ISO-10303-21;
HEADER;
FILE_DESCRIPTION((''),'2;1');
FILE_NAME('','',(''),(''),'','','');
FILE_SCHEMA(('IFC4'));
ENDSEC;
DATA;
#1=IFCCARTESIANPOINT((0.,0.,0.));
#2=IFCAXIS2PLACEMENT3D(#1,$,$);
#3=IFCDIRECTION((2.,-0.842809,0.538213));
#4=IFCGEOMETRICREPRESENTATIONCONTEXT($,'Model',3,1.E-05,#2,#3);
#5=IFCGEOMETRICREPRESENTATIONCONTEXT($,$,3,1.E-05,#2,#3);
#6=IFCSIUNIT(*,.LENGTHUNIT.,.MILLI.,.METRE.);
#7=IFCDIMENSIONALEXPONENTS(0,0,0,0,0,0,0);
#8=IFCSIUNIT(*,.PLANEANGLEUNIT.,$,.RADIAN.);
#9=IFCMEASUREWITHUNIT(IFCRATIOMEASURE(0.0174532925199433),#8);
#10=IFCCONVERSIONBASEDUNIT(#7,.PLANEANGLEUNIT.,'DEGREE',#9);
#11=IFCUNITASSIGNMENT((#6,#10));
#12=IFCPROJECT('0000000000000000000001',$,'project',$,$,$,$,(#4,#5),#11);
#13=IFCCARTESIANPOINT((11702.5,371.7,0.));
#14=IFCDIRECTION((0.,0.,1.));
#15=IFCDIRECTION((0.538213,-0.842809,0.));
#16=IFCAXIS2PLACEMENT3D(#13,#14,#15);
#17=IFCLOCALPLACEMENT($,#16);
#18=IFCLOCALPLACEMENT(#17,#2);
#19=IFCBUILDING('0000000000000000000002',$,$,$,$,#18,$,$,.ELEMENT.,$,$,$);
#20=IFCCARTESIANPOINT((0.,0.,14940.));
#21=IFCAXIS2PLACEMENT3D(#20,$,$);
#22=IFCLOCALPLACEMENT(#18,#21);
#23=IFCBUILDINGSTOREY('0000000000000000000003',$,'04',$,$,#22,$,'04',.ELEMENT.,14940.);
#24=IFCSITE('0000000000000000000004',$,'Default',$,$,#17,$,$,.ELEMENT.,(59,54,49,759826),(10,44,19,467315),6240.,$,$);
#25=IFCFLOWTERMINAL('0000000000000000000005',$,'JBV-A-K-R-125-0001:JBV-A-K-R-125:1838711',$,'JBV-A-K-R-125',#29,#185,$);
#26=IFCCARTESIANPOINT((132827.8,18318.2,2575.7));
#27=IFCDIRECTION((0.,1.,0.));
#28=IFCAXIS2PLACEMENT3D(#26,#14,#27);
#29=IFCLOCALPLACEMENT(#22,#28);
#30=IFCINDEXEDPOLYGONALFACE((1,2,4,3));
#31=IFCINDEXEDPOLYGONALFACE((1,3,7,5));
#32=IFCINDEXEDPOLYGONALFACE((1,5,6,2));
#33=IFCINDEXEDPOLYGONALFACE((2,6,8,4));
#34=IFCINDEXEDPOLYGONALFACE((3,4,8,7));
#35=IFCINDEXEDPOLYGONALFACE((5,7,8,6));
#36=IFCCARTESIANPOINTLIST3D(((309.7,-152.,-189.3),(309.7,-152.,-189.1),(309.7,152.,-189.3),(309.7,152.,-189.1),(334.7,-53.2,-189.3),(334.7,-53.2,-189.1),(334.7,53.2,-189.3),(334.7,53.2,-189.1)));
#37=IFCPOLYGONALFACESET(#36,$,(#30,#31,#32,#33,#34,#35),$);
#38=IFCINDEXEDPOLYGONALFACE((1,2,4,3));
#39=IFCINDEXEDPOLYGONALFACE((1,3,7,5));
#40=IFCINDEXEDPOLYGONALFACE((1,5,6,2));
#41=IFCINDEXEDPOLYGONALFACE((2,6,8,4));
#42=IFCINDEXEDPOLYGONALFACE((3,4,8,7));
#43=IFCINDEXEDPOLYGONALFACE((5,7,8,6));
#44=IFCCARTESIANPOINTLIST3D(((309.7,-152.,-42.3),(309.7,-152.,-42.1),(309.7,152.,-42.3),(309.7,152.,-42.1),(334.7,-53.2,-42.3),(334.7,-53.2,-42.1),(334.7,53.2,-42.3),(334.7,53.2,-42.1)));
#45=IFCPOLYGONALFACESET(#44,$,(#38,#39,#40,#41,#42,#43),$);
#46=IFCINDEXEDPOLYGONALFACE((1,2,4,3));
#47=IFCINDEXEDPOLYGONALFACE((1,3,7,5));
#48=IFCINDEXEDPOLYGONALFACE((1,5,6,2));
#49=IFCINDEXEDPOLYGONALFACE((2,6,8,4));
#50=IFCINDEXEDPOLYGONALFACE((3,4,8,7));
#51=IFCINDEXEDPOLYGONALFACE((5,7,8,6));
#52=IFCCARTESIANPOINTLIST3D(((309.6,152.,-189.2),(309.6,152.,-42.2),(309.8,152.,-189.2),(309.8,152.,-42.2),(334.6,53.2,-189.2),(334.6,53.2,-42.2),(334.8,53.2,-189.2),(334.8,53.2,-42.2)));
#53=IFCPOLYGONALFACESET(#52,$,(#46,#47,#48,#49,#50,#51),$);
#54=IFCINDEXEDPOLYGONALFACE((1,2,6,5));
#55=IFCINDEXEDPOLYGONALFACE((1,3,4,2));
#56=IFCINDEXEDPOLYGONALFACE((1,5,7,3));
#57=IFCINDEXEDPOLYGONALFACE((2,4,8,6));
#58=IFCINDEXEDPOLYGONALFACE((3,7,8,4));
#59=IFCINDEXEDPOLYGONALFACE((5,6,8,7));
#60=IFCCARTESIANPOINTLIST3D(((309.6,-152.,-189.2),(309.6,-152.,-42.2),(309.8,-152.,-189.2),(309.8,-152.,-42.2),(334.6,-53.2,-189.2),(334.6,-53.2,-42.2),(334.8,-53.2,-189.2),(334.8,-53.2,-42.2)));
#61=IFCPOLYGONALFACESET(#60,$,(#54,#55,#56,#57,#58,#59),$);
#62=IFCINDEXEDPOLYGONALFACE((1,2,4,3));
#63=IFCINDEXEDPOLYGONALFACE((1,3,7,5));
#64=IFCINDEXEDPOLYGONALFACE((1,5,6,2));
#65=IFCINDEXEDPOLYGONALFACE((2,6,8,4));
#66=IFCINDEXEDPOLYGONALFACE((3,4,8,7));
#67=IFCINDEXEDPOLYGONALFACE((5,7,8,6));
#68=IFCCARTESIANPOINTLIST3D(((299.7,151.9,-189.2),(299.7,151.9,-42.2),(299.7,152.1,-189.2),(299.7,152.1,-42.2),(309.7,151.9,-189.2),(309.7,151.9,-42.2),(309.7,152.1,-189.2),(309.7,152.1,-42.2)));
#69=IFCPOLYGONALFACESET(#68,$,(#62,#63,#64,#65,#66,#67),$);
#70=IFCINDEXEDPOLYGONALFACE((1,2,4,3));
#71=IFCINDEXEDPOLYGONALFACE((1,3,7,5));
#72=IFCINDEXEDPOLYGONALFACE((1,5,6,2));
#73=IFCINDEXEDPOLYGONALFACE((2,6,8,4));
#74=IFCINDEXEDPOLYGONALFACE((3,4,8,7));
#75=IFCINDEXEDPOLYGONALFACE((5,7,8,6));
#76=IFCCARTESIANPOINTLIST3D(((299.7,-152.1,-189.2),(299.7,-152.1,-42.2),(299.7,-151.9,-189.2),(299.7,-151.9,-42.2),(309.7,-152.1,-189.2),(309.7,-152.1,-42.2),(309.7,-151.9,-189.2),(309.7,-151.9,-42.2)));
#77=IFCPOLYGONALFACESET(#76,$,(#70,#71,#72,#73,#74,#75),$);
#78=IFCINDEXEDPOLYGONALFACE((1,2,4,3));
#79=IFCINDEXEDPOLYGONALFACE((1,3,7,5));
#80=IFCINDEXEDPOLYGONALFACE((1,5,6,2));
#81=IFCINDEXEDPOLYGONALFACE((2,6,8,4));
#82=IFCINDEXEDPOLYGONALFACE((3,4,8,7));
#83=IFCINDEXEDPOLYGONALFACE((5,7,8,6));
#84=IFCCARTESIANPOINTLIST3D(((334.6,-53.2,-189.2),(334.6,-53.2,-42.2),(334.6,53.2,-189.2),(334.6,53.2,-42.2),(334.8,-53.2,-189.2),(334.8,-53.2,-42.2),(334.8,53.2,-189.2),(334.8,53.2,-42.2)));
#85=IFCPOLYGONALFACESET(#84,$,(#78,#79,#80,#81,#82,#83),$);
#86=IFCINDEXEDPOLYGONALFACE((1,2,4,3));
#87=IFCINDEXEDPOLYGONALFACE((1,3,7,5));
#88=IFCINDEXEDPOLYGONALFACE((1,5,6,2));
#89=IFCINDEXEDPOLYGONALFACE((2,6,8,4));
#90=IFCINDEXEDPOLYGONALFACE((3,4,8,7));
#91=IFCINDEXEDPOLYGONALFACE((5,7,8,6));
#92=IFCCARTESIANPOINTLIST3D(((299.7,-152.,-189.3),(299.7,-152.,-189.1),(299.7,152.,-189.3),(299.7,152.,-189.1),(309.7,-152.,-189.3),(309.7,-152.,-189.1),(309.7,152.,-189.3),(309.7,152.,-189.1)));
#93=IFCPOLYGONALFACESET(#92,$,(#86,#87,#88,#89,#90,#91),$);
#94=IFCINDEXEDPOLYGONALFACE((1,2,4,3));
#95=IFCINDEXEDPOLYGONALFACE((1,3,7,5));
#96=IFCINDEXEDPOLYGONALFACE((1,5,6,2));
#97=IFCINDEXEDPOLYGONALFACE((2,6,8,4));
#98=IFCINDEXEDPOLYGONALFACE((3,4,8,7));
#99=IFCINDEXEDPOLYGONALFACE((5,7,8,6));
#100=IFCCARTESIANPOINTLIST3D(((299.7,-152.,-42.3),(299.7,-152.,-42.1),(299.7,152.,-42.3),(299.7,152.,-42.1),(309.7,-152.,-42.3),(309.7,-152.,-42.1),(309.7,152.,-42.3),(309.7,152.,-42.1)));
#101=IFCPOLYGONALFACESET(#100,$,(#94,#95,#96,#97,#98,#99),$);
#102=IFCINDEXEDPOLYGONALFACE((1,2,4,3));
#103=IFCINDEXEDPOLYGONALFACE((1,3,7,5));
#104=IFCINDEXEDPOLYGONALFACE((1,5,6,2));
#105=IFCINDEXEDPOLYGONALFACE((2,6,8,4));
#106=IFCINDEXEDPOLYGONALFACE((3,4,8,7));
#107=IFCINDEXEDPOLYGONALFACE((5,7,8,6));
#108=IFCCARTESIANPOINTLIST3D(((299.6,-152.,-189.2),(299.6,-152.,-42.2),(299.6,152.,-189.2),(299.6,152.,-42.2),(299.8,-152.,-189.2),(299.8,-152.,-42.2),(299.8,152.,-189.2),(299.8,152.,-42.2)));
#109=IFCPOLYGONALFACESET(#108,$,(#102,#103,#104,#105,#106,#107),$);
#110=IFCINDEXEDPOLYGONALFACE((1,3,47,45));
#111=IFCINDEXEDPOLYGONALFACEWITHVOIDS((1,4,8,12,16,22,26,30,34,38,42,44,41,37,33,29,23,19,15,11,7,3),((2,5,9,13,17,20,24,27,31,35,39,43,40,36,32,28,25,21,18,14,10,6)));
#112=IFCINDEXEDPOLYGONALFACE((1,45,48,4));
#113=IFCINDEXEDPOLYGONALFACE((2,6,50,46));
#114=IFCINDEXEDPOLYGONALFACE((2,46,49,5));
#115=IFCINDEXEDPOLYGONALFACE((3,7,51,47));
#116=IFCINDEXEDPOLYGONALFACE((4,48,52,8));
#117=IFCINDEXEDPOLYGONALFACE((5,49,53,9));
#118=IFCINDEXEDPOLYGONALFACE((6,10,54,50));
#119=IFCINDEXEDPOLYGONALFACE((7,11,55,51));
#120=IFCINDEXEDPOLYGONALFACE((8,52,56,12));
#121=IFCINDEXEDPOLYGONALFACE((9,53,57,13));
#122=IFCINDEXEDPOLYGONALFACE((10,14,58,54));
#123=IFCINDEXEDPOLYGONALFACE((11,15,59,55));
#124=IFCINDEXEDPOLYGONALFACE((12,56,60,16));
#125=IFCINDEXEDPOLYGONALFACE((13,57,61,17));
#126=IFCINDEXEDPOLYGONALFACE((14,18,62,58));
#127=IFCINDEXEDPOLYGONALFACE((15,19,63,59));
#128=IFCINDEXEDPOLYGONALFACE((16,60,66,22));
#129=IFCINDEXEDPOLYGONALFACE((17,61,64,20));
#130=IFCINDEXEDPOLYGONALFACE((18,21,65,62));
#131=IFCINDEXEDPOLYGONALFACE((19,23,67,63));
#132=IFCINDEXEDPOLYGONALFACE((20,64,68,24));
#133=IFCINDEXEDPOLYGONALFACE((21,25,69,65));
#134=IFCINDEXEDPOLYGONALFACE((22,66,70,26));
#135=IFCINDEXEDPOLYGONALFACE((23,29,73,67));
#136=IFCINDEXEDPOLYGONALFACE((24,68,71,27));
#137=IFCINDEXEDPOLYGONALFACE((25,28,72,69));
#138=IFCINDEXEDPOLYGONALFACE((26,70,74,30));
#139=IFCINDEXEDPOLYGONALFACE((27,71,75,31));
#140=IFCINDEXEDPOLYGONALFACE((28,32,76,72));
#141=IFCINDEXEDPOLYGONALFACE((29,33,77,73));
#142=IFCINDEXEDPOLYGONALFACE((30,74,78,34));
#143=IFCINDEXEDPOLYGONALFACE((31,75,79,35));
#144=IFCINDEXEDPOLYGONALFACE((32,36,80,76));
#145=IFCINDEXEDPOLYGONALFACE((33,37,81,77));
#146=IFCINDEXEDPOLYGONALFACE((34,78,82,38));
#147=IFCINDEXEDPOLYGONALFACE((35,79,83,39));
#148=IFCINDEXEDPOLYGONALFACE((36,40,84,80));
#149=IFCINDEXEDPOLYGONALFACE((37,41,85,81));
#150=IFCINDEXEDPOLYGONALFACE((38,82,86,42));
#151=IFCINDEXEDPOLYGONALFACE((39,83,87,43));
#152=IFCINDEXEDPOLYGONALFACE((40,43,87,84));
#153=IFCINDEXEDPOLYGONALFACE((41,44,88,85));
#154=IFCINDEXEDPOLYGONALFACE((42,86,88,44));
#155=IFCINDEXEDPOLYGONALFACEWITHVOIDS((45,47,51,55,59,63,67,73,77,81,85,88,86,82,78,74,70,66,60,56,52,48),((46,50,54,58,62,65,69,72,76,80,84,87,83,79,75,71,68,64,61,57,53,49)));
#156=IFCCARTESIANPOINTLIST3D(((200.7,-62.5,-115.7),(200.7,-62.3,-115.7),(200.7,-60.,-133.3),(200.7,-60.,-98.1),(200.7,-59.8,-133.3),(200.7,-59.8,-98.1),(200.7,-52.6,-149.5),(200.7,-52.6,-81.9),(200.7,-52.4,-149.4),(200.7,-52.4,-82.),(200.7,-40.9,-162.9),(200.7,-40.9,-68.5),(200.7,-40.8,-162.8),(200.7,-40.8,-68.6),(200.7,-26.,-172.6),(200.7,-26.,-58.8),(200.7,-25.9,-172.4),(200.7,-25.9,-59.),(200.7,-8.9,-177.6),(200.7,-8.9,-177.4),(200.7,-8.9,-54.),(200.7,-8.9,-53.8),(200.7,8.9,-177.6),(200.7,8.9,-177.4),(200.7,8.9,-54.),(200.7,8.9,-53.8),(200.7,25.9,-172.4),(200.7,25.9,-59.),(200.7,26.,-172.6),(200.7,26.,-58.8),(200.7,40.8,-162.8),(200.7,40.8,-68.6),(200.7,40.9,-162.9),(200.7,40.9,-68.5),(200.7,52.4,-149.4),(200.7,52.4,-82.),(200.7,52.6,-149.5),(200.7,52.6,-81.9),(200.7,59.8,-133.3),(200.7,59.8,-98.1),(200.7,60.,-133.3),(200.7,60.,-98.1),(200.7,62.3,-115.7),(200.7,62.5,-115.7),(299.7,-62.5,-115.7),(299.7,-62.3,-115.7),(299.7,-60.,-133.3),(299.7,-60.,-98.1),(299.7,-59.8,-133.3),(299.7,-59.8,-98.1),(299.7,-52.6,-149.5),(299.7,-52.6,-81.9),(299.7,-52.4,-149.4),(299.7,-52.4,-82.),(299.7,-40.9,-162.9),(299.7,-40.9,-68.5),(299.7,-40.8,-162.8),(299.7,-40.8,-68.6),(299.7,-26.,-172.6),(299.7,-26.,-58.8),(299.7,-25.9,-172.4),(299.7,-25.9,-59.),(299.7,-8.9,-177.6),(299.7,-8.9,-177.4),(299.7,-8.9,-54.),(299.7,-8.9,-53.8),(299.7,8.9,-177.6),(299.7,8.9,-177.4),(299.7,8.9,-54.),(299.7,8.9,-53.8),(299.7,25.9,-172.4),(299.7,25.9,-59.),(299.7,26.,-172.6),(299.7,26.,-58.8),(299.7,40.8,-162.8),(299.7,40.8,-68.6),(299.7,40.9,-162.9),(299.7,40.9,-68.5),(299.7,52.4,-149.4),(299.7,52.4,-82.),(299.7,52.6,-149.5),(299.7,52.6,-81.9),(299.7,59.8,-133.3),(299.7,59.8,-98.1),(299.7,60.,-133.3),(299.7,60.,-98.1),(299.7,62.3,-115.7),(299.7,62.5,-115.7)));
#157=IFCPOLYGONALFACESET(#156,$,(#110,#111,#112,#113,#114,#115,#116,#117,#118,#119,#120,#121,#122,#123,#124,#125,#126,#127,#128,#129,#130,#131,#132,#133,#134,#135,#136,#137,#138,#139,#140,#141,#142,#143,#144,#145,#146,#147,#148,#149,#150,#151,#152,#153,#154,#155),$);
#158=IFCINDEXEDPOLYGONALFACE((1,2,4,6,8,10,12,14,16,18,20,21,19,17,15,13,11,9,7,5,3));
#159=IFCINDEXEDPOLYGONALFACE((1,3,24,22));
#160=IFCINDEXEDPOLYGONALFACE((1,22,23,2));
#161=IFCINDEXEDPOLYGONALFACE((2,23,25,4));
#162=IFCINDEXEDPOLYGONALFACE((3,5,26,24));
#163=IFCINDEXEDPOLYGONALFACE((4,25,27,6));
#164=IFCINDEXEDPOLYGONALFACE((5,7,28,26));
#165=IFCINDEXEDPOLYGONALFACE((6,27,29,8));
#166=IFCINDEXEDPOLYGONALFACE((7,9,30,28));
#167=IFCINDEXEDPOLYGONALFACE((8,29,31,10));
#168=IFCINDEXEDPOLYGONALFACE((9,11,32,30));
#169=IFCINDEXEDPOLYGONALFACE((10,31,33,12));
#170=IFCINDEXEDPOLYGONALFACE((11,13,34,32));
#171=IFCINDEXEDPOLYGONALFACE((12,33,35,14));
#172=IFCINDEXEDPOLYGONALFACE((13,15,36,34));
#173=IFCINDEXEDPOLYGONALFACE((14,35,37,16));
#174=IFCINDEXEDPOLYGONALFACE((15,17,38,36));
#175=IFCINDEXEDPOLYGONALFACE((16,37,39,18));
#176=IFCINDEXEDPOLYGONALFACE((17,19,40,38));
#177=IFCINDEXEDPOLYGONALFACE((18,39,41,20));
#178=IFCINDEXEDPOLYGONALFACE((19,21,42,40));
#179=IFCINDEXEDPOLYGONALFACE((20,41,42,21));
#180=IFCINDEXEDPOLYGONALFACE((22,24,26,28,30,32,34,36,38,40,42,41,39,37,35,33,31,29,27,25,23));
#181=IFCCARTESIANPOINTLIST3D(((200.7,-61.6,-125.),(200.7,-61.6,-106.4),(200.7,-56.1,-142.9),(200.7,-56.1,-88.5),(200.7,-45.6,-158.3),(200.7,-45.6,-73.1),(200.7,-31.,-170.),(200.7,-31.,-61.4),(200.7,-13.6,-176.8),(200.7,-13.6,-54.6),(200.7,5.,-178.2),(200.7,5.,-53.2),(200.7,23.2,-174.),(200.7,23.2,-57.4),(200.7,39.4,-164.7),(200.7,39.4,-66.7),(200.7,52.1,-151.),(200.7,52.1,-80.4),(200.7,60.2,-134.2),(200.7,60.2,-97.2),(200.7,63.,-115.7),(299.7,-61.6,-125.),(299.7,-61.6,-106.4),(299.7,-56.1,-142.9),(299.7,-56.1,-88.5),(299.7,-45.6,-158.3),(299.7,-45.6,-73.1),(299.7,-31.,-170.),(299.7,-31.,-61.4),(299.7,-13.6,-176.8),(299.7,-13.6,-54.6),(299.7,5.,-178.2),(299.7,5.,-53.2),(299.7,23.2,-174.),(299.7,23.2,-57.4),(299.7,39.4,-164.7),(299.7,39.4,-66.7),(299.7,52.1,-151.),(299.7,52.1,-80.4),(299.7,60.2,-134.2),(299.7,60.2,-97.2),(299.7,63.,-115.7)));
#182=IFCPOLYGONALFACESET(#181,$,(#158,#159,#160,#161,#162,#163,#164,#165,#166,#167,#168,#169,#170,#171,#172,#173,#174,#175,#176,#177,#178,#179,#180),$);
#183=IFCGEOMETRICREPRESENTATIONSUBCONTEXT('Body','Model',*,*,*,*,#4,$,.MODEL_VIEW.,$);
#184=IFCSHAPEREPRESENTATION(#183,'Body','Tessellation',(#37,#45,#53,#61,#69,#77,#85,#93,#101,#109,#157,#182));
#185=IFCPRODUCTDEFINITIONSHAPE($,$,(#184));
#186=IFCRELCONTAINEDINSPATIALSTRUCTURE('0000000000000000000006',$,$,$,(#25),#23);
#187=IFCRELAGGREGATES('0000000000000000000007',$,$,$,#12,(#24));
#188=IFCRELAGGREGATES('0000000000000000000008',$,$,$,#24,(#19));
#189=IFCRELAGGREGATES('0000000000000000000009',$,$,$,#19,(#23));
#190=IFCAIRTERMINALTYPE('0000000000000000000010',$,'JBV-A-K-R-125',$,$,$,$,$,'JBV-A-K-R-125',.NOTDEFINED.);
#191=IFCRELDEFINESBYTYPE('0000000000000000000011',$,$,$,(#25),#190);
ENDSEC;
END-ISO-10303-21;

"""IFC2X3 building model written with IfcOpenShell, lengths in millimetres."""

from ifc_helpers import new_model, entity, si_unit, converted_unit, direction, frame, frame_2d, origin, origin_2d_with_axis, place, context, subcontext, project, spatial, polyline, circle_curve, parameter, trimmed, segment, composite_curve, rectangle, circle, outline, extrude, source, transform, mapped, type_object, type_shapes, element, save


model = new_model("IFC2X3")

# Units and contexts
model_context = context("Model", 3, precision=1e-05, world=origin(), true_north=direction((2.0, -0.842809, 0.538213)))
context_of_model = context(None, 3, precision=1e-05, world=origin(), true_north=direction((2.0, -0.842809, 0.538213)))
body_context = subcontext(model_context, "Body", "Model", "MODEL_VIEW")
ifc_project = project(units=[si_unit("LENGTHUNIT", "METRE", prefix="MILLI"), converted_unit("PLANEANGLEUNIT", "DEGREE", entity("IfcRatioMeasure", 0.0174532925199433), si_unit("PLANEANGLEUNIT", "RADIAN"), dimensions=[0, 0, 0, 0, 0, 0, 0])], contexts=[model_context, context_of_model])

# Site, building, storey
site_placement = place(None, frame((11702.5, 371.7, 0.0), z_axis=(0.0, 0.0, 1.0), x_axis=(0.538213, -0.842809, 0.0)))
site = spatial("IfcSite", under=ifc_project, at=site_placement, Name="Default", CompositionType="ELEMENT", RefLatitude=(59, 54, 49, 759826), RefLongitude=(10, 44, 19, 467315), RefElevation=6240.0)
building_placement = place(site_placement, origin())
building = spatial("IfcBuilding", under=site, at=building_placement, CompositionType="ELEMENT")
storey_placement = place(building_placement, frame((0.0, 0.0, 14940.0)))
storey = spatial("IfcBuildingStorey", under=building, at=storey_placement, Name="04", LongName="04", CompositionType="ELEMENT", Elevation=14940.0)

# Flow terminal
air_terminal_type_1 = type_object("IfcAirTerminalType", Name="JBV-A-K-R-125", ElementType="JBV-A-K-R-125", PredefinedType="NOTDEFINED")
shared_shape_1 = source(origin(), body_context, "Body", "SweptSolid", [
    extrude(outline(polyline([(-152.0, -12.5), (152.0, -12.5), (53.2, 12.5), (-53.2, 12.5), (-152.0, -12.5)])), frame((322.2, 0.0, -189.3), z_axis=(0.0, 0.0, 1.0), x_axis=(0.0, -1.0, 0.0)), (0.0, 0.0, 1.0), 0.2),
    extrude(outline(polyline([(-152.0, -12.5), (152.0, -12.5), (53.2, 12.5), (-53.2, 12.5), (-152.0, -12.5)])), frame((322.2, 0.0, -42.3), z_axis=(0.0, 0.0, 1.0), x_axis=(0.0, -1.0, 0.0)), (0.0, 0.0, 1.0), 0.2),
    extrude(rectangle(XDim=0.2, YDim=101.9, at=frame_2d((0.0, 0.0), x_axis=(1.0, 0.0))), frame((322.2, 102.6, -189.2), z_axis=(0.0, 0.0, 1.0), x_axis=(0.969446, 0.245305, 0.0)), (0.0, 0.0, 1.0), 147.0),
    extrude(rectangle(XDim=0.2, YDim=101.9, at=frame_2d((0.0, 0.0), x_axis=(1.0, 0.0))), frame((322.2, -102.6, -189.2), z_axis=(0.0, 0.0, 1.0), x_axis=(-0.969446, 0.245305, 0.0)), (0.0, 0.0, 1.0), 147.0),
    extrude(rectangle(XDim=0.2, YDim=10.0, at=frame_2d((0.0, 0.0), x_axis=(1.0, 0.0))), frame((304.7, 152.0, -189.2), z_axis=(0.0, 0.0, 1.0), x_axis=(0.0, 1.0, 0.0)), (0.0, 0.0, 1.0), 147.0),
    extrude(rectangle(XDim=0.2, YDim=10.0, at=frame_2d((0.0, 0.0), x_axis=(1.0, 0.0))), frame((304.7, -152.0, -189.2), z_axis=(0.0, 0.0, 1.0), x_axis=(0.0, 1.0, 0.0)), (0.0, 0.0, 1.0), 147.0),
    extrude(rectangle(XDim=0.2, YDim=106.4, at=frame_2d((0.0, 0.0), x_axis=(1.0, 0.0))), frame((334.7, 0.0, -189.2)), (0.0, 0.0, 1.0), 147.0),
    extrude(rectangle(XDim=304.0, YDim=10.0, at=frame_2d((0.0, 0.0), x_axis=(1.0, 0.0))), frame((304.7, 0.0, -189.3), z_axis=(0.0, 0.0, 1.0), x_axis=(0.0, -1.0, 0.0)), (0.0, 0.0, 1.0), 0.2),
    extrude(rectangle(XDim=304.0, YDim=10.0, at=frame_2d((0.0, 0.0), x_axis=(1.0, 0.0))), frame((304.7, 0.0, -42.3), z_axis=(0.0, 0.0, 1.0), x_axis=(0.0, -1.0, 0.0)), (0.0, 0.0, 1.0), 0.2),
    extrude(rectangle(XDim=0.2, YDim=304.0, at=frame_2d((0.0, 0.0), x_axis=(1.0, 0.0))), frame((299.7, 0.0, -189.2)), (0.0, 0.0, 1.0), 147.0),
    extrude(outline(composite_curve([segment(trimmed(circle_curve(origin_2d_with_axis(), 62.5), [parameter(0.0)], [parameter(180.0)], True, "PARAMETER"), True, "CONTINUOUS"), segment(trimmed(circle_curve(origin_2d_with_axis(), 62.5), [parameter(180.0)], [parameter(360.0)], True, "PARAMETER"), True, "CONTINUOUS")], self_intersect=False), holes=[composite_curve([segment(trimmed(circle_curve(origin_2d_with_axis(), 62.3), [parameter(180.0)], [parameter(360.0)], True, "PARAMETER"), False, "CONTINUOUS"), segment(trimmed(circle_curve(origin_2d_with_axis(), 62.3), [parameter(0.0)], [parameter(180.0)], True, "PARAMETER"), False, "CONTINUOUS")], self_intersect=False)]), frame((200.7, 0.0, -115.7), z_axis=(1.0, 0.0, 0.0), x_axis=(0.0, 1.0, 0.0)), (0.0, 0.0, 1.0), 99.0),
    extrude(circle(Radius=62.6, at=frame_2d((0.0, 0.0), x_axis=(1.0, 0.0))), frame((200.7, 0.3, -115.7), z_axis=(1.0, 0.0, 0.0), x_axis=(0.0, 1.0, 0.0)), (0.0, 0.0, 1.0), 99.0),
])
type_shapes(air_terminal_type_1, [shared_shape_1])
for number, where, z_axis, x_axis, name in (
    (1, (132827.8, 18318.2, 2575.7), (0.0, 0.0, 1.0), (0.0, 1.0, 0.0), "JBV-A-K-R-125-0001:JBV-A-K-R-125:1838711"),
):
    element("IfcFlowTerminal", number, at=place(storey_placement, frame(where, z_axis=z_axis, x_axis=x_axis)), inside=storey, type_object=air_terminal_type_1, Name=name, ObjectType="JBV-A-K-R-125", context=body_context, shape_type="MappedRepresentation", body=[
        mapped(shared_shape_1, transform((0.0, 0.0, 0.0), scale=1.0)),
    ])

save(model, "model.ifc")
